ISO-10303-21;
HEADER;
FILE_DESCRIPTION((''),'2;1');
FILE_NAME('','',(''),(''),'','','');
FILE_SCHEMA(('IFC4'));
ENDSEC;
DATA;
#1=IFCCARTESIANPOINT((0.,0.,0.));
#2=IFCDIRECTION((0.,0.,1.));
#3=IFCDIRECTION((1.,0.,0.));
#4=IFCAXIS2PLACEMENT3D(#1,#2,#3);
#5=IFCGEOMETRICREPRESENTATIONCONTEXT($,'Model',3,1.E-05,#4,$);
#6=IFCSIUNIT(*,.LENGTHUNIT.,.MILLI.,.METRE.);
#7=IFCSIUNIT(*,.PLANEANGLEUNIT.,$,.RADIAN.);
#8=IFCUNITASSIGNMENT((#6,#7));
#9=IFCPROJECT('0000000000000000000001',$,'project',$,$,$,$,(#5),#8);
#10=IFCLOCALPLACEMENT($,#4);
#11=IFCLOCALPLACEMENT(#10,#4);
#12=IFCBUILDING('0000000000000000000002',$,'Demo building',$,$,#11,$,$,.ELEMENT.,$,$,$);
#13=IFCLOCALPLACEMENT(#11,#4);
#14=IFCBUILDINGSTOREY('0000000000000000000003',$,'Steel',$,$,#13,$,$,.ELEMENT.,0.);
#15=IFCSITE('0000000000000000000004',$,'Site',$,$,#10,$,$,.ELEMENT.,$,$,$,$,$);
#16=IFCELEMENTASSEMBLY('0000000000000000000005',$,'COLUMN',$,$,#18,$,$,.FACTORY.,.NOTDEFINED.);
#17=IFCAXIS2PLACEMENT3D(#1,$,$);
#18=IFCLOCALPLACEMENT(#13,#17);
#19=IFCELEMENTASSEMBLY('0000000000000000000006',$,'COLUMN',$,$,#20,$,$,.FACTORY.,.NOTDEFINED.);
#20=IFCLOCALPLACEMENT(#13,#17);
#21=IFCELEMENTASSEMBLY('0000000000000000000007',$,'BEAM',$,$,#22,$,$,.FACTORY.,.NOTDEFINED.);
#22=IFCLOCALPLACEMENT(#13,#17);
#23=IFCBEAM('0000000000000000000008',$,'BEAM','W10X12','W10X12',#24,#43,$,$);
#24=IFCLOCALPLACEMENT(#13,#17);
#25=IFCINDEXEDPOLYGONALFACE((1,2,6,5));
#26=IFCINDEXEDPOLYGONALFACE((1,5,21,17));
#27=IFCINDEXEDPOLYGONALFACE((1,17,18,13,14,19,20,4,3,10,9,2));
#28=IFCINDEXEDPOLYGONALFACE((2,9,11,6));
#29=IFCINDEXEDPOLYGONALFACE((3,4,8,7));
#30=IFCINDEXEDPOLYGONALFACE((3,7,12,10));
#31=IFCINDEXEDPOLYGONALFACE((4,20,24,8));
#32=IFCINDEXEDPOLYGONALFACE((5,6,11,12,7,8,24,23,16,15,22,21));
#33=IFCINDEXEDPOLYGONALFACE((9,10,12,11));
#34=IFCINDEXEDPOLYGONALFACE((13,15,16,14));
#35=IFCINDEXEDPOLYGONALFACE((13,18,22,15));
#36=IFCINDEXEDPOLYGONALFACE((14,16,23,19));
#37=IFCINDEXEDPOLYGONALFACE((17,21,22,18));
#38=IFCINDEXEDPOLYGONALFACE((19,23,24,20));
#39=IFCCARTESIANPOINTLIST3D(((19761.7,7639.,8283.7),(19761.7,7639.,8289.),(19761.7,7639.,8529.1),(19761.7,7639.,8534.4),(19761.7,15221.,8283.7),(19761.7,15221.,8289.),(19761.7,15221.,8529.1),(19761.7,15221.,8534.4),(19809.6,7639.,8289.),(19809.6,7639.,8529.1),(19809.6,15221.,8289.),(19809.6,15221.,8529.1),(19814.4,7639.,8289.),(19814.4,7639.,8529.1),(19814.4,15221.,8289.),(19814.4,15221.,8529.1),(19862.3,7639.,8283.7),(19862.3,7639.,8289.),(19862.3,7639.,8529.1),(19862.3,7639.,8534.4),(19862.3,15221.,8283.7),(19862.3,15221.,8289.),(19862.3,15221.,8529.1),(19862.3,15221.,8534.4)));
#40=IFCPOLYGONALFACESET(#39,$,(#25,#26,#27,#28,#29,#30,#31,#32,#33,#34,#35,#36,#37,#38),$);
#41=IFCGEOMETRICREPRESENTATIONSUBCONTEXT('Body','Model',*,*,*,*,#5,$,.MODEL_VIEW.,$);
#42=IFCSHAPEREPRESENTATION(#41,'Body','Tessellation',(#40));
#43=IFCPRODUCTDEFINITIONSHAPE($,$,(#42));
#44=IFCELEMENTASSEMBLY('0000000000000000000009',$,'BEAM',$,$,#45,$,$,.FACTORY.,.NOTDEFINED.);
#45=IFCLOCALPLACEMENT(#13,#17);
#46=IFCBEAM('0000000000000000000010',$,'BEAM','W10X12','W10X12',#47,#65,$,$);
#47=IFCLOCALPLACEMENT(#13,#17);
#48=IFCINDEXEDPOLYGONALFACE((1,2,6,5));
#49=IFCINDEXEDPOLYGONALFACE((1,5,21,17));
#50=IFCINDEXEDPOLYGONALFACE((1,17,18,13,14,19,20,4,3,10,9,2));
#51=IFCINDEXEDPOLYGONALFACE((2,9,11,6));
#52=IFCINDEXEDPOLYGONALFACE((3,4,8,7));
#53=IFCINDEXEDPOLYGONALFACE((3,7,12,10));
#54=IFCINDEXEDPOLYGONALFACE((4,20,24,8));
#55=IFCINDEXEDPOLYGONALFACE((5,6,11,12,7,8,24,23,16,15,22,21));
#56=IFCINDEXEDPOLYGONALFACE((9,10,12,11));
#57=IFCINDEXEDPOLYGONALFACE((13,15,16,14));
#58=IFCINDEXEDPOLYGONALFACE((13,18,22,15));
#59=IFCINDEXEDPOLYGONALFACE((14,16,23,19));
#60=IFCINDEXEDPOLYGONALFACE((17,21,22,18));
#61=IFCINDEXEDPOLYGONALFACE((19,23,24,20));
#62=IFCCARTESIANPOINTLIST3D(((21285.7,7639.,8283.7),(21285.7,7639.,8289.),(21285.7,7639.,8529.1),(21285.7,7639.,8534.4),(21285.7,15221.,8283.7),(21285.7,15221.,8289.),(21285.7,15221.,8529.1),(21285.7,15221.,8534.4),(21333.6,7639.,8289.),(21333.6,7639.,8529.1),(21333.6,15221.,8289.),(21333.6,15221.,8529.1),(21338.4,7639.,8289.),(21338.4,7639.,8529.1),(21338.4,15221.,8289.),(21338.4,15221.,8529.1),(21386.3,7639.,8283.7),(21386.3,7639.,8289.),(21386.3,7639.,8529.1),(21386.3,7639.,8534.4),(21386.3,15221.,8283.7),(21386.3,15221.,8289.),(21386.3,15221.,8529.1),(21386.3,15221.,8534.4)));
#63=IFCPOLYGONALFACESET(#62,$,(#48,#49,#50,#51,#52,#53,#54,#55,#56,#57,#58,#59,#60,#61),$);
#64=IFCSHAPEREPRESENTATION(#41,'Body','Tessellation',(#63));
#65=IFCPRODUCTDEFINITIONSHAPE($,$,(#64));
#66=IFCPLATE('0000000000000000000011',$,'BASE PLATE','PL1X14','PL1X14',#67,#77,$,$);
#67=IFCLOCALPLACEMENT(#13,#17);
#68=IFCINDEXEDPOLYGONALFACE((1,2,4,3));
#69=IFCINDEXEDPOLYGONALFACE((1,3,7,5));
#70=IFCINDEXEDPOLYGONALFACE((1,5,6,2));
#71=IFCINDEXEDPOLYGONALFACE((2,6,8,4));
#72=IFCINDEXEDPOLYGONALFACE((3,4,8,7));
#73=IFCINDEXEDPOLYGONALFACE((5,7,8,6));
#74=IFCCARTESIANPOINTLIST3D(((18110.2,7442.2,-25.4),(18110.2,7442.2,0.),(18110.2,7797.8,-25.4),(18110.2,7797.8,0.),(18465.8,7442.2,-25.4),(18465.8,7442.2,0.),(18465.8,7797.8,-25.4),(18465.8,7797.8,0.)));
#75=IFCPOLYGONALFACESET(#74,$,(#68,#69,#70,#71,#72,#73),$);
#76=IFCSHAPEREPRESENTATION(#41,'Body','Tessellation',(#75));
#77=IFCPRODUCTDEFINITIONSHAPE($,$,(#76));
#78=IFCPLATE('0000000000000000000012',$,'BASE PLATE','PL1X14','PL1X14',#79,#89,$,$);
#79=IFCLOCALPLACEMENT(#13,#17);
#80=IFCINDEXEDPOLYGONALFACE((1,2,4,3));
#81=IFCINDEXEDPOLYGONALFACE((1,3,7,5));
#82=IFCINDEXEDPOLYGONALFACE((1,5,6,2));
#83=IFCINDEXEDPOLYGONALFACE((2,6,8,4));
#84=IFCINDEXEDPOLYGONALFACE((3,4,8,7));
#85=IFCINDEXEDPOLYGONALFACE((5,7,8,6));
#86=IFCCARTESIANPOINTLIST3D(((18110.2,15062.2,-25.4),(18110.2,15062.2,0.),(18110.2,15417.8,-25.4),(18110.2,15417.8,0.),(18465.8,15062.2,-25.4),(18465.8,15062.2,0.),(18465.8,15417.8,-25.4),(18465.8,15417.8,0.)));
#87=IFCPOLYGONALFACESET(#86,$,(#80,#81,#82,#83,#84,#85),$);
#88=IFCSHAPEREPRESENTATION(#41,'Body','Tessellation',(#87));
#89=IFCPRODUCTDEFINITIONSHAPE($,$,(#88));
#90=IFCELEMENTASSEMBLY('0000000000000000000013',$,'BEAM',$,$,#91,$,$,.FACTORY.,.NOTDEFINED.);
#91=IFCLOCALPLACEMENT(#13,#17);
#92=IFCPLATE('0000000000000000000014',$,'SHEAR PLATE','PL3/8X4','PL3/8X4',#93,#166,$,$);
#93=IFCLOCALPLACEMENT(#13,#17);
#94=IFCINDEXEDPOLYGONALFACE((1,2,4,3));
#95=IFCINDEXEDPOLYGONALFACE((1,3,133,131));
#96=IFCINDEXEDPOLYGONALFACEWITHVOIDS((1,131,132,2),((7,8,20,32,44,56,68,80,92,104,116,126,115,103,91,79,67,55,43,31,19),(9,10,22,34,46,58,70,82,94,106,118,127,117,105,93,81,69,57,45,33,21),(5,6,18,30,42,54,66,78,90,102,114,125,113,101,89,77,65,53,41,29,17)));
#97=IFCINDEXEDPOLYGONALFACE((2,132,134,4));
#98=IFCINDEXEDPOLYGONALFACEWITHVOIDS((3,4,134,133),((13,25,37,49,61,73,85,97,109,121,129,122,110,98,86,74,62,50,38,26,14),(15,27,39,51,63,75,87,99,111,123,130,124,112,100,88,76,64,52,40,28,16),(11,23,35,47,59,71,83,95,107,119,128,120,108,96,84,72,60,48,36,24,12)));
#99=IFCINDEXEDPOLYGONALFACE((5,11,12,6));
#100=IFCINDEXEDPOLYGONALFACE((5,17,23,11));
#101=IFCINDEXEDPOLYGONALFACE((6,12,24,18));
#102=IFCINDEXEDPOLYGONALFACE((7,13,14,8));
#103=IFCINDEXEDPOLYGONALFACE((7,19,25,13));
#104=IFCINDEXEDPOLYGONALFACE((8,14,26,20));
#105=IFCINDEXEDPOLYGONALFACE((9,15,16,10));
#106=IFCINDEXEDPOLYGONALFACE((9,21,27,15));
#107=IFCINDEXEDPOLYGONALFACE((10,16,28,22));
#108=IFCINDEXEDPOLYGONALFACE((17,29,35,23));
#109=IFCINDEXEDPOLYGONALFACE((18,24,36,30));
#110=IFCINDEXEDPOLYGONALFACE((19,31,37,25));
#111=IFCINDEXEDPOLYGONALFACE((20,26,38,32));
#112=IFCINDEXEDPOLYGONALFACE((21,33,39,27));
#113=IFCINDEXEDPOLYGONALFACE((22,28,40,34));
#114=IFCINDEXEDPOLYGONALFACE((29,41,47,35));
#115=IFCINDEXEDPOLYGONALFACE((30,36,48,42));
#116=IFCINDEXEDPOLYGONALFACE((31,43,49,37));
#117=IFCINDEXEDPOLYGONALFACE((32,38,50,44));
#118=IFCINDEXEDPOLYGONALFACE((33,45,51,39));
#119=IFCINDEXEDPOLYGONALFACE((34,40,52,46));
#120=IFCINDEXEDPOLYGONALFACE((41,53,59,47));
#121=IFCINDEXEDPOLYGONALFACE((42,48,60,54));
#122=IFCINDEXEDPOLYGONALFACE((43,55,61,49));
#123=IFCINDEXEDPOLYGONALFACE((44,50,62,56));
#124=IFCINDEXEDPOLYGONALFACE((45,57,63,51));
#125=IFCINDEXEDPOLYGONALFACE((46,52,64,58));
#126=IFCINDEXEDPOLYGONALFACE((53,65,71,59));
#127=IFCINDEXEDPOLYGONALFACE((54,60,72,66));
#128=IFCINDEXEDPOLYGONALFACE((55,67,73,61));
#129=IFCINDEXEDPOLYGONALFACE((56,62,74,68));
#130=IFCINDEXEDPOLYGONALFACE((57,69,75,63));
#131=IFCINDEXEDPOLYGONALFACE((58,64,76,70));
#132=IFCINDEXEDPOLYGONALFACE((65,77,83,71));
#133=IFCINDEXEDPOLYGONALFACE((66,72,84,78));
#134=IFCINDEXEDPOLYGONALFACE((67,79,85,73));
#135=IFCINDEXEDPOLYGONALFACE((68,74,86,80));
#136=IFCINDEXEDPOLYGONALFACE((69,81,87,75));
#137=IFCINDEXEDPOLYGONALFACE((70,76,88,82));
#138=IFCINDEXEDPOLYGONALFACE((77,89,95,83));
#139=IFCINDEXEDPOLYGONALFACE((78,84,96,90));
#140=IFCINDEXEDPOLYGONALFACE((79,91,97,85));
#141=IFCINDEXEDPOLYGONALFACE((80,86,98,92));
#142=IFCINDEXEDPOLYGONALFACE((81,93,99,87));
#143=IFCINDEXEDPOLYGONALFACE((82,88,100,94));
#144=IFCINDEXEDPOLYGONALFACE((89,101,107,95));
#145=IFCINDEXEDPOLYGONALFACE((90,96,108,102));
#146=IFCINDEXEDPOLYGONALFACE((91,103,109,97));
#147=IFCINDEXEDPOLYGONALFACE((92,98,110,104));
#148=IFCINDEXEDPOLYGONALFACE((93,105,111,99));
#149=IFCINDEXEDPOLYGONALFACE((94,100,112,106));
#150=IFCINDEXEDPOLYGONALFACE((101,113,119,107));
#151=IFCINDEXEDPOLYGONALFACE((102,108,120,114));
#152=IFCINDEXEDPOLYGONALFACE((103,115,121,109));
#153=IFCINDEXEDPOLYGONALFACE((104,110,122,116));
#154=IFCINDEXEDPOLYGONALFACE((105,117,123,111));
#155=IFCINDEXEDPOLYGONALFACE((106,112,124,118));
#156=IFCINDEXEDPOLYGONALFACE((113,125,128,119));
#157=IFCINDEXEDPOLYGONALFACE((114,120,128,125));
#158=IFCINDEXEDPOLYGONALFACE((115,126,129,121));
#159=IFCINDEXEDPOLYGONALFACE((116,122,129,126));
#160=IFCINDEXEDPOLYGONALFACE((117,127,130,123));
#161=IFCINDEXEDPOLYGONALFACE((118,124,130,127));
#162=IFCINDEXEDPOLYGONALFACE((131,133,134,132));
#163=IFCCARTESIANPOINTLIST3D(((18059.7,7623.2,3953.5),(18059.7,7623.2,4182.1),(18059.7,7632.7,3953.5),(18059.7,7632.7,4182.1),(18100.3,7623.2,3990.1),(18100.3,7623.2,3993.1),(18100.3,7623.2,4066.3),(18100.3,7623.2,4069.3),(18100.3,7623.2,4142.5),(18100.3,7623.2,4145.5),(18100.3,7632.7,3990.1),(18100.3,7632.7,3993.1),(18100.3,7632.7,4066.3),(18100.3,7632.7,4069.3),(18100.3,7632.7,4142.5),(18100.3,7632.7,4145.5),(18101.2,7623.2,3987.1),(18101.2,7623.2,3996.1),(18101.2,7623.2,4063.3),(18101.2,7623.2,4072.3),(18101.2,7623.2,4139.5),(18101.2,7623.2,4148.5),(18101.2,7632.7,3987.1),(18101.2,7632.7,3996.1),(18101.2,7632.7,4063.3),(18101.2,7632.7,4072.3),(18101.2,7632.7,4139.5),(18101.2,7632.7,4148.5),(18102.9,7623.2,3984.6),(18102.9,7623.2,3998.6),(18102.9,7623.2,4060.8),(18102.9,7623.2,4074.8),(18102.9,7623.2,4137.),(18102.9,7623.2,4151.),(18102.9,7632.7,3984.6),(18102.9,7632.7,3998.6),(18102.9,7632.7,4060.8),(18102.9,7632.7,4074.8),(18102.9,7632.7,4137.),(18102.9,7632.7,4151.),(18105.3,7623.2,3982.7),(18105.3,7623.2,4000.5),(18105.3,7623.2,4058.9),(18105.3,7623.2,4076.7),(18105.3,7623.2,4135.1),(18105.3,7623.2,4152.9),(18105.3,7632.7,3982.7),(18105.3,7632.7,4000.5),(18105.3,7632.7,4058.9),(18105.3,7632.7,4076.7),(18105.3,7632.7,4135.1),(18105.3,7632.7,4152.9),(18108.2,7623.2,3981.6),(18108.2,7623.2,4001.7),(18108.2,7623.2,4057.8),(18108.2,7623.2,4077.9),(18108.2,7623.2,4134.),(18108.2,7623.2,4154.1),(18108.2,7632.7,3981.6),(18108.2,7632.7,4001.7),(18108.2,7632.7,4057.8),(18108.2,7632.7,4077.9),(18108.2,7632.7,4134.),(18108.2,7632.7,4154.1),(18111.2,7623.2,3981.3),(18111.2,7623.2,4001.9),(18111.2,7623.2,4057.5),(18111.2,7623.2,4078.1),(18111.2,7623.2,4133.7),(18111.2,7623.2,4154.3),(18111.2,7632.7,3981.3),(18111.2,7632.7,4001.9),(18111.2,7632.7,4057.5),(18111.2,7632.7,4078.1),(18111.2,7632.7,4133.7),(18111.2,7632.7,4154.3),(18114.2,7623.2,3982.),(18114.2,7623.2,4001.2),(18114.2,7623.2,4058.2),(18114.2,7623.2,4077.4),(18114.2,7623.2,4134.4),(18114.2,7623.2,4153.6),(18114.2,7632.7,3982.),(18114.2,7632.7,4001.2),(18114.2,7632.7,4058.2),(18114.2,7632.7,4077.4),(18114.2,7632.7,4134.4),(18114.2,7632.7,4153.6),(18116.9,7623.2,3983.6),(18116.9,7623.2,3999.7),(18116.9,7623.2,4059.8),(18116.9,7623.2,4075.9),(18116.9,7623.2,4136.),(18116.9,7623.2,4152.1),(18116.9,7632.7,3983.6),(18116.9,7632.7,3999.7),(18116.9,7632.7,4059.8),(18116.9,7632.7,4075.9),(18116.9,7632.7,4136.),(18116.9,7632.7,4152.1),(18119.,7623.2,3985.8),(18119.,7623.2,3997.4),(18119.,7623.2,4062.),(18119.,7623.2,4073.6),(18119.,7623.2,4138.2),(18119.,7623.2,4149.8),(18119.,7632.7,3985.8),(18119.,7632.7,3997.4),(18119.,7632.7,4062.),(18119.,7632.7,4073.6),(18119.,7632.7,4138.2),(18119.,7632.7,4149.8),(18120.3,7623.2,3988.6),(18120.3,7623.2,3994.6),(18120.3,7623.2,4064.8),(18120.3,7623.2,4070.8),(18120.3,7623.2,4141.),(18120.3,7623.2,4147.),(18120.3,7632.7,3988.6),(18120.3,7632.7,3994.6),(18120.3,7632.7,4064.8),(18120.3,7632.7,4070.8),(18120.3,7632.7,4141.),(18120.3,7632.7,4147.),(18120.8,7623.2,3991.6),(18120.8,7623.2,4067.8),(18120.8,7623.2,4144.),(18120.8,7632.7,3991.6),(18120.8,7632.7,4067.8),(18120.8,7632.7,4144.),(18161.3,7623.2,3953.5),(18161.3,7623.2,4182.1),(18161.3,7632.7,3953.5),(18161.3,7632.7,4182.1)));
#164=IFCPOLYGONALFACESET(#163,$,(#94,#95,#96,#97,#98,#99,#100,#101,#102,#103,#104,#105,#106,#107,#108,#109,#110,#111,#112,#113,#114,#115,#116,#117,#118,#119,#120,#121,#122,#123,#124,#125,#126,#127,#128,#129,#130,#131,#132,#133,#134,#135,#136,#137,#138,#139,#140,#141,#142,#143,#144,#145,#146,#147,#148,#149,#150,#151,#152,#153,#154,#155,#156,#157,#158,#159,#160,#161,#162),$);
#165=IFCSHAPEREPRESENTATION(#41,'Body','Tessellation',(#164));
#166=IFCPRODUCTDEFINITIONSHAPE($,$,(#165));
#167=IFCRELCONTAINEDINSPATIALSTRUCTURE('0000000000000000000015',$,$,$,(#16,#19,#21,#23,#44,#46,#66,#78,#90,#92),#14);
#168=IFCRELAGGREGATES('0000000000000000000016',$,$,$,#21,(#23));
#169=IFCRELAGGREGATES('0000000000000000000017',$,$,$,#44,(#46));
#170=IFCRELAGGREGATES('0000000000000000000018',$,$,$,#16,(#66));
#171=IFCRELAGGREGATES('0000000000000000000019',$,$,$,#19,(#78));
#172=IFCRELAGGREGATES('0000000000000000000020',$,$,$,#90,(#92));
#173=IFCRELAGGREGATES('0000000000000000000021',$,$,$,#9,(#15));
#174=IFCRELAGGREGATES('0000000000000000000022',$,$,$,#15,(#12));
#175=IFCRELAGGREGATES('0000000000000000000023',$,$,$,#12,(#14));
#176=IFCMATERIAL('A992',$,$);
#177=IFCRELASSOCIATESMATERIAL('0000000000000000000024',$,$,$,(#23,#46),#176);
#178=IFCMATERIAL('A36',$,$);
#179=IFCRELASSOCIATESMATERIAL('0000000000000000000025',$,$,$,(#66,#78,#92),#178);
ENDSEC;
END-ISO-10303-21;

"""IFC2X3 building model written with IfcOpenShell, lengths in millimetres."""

from ifc_helpers import new_model, si_unit, frame, frame_2d, origin, origin_with_axes, origin_2d, place, context, subcontext, project, spatial, rectangle, circle, i_section, extrude, boolean, material, element, aggregate, save


model = new_model("IFC2X3")

# Units and contexts
model_context = context("Model", 3, precision=1e-05, world=origin_with_axes())
body_context = subcontext(model_context, "Body", "Model", "MODEL_VIEW")
ifc_project = project(units=[si_unit("LENGTHUNIT", "METRE", prefix="MILLI"), si_unit("PLANEANGLEUNIT", "RADIAN")], contexts=[model_context])

# Site, building, storey
site_placement = place(None, origin_with_axes())
site = spatial("IfcSite", under=ifc_project, at=site_placement, Name="Site", CompositionType="ELEMENT")
building_placement = place(site_placement, origin_with_axes())
building = spatial("IfcBuilding", under=site, at=building_placement, Name="Demo building", CompositionType="ELEMENT")
placement = place(building_placement, origin_with_axes())
storey = spatial("IfcBuildingStorey", under=building, at=placement, Name="Steel", CompositionType="ELEMENT", Elevation=0.0)

# Element assemblies
assembly_1 = element("IfcElementAssembly", 1, at=placement, inside=storey, Name="COLUMN", AssemblyPlace="FACTORY", PredefinedType="NOTDEFINED")
ifc_material_1 = material(Name="A992")
assembly_2 = element("IfcElementAssembly", 2, at=placement, inside=storey, Name="COLUMN", AssemblyPlace="FACTORY", PredefinedType="NOTDEFINED")

# Element assemblies, beams
assembly_3 = element("IfcElementAssembly", 3, at=placement, inside=storey, Name="BEAM", AssemblyPlace="FACTORY", PredefinedType="NOTDEFINED")
beam_1_placement = place(placement, frame((19812.0, 7639.1, 8409.1), z_axis=(0.0, 1.0, 0.0), x_axis=(-1.0, 0.0, 0.0)))
beam_1 = element("IfcBeam", 4, at=beam_1_placement, inside=storey, material=ifc_material_1, Name="BEAM", Description="W10X12", ObjectType="W10X12", context=body_context, shape_type="SweptSolid", body=[
    extrude(i_section(OverallWidth=100.6, OverallDepth=250.7, WebThickness=4.8, FlangeThickness=5.3, at=origin_2d()), origin(), (0.0, 0.0, 1.0), 7581.9),
])
aggregate(assembly_3, [beam_1])
assembly_4 = element("IfcElementAssembly", 5, at=placement, inside=storey, Name="BEAM", AssemblyPlace="FACTORY", PredefinedType="NOTDEFINED")
beam_2_placement = place(placement, frame((21336.0, 7639.1, 8409.1), z_axis=(0.0, 1.0, 0.0), x_axis=(-1.0, 0.0, 0.0)))
beam_2 = element("IfcBeam", 6, at=beam_2_placement, inside=storey, material=ifc_material_1, Name="BEAM", Description="W10X12", ObjectType="W10X12", context=body_context, shape_type="SweptSolid", body=[
    extrude(i_section(OverallWidth=100.6, OverallDepth=250.7, WebThickness=4.8, FlangeThickness=5.3, at=origin_2d()), origin(), (0.0, 0.0, 1.0), 7581.9),
])
aggregate(assembly_4, [beam_2])

# Plates
ifc_material_2 = material(Name="A36")
plate_1_placement = place(placement, frame((18110.2, 7442.2, -25.4), z_axis=(0.0, 0.0, 1.0), x_axis=(1.0, 0.0, 0.0)))
plate_1 = element("IfcPlate", 7, at=plate_1_placement, inside=storey, material=ifc_material_2, Name="BASE PLATE", Description="PL1X14", ObjectType="PL1X14", context=body_context, shape_type="SweptSolid", body=[
    extrude(rectangle(XDim=355.6, YDim=355.6, at=frame_2d((177.8, 177.8))), origin(), (0.0, 0.0, 1.0), 25.4),
])
aggregate(assembly_1, [plate_1])
plate_2_placement = place(placement, frame((18110.2, 15062.2, -25.4), z_axis=(0.0, 0.0, 1.0), x_axis=(1.0, 0.0, 0.0)))
plate_2 = element("IfcPlate", 8, at=plate_2_placement, inside=storey, material=ifc_material_2, Name="BASE PLATE", Description="PL1X14", ObjectType="PL1X14", context=body_context, shape_type="SweptSolid", body=[
    extrude(rectangle(XDim=355.6, YDim=355.6, at=frame_2d((177.8, 177.8))), origin(), (0.0, 0.0, 1.0), 25.4),
])
aggregate(assembly_2, [plate_2])

# Element assembly, plate
assembly_5 = element("IfcElementAssembly", 9, at=placement, inside=storey, Name="BEAM", AssemblyPlace="FACTORY", PredefinedType="NOTDEFINED")
plate_3_placement = place(placement, frame((18059.7, 7632.7, 3953.5), z_axis=(0.0, -1.0, 0.0), x_axis=(1.0, 0.0, 0.0)))
plate_3 = element("IfcPlate", 10, at=plate_3_placement, inside=storey, material=ifc_material_2, Name="SHEAR PLATE", Description="PL3/8X4", ObjectType="PL3/8X4", context=body_context, shape_type="CSG", body=[
    boolean("DIFFERENCE", boolean("DIFFERENCE", boolean("DIFFERENCE", extrude(rectangle(XDim=101.6, YDim=228.6, at=frame_2d((50.8, 114.3))), origin(), (0.0, 0.0, 1.0), 9.5), extrude(circle(Radius=10.3, at=frame_2d((50.8, 38.1))), frame((0.0, 0.0, -5.0)), (0.0, 0.0, 1.0), 19.5)), extrude(circle(Radius=10.3, at=frame_2d((50.8, 114.3))), frame((0.0, 0.0, -5.0)), (0.0, 0.0, 1.0), 19.5)), extrude(circle(Radius=10.3, at=frame_2d((50.8, 190.5))), frame((0.0, 0.0, -5.0)), (0.0, 0.0, 1.0), 19.5)),
])
aggregate(assembly_5, [plate_3])

save(model, "model.ifc")
